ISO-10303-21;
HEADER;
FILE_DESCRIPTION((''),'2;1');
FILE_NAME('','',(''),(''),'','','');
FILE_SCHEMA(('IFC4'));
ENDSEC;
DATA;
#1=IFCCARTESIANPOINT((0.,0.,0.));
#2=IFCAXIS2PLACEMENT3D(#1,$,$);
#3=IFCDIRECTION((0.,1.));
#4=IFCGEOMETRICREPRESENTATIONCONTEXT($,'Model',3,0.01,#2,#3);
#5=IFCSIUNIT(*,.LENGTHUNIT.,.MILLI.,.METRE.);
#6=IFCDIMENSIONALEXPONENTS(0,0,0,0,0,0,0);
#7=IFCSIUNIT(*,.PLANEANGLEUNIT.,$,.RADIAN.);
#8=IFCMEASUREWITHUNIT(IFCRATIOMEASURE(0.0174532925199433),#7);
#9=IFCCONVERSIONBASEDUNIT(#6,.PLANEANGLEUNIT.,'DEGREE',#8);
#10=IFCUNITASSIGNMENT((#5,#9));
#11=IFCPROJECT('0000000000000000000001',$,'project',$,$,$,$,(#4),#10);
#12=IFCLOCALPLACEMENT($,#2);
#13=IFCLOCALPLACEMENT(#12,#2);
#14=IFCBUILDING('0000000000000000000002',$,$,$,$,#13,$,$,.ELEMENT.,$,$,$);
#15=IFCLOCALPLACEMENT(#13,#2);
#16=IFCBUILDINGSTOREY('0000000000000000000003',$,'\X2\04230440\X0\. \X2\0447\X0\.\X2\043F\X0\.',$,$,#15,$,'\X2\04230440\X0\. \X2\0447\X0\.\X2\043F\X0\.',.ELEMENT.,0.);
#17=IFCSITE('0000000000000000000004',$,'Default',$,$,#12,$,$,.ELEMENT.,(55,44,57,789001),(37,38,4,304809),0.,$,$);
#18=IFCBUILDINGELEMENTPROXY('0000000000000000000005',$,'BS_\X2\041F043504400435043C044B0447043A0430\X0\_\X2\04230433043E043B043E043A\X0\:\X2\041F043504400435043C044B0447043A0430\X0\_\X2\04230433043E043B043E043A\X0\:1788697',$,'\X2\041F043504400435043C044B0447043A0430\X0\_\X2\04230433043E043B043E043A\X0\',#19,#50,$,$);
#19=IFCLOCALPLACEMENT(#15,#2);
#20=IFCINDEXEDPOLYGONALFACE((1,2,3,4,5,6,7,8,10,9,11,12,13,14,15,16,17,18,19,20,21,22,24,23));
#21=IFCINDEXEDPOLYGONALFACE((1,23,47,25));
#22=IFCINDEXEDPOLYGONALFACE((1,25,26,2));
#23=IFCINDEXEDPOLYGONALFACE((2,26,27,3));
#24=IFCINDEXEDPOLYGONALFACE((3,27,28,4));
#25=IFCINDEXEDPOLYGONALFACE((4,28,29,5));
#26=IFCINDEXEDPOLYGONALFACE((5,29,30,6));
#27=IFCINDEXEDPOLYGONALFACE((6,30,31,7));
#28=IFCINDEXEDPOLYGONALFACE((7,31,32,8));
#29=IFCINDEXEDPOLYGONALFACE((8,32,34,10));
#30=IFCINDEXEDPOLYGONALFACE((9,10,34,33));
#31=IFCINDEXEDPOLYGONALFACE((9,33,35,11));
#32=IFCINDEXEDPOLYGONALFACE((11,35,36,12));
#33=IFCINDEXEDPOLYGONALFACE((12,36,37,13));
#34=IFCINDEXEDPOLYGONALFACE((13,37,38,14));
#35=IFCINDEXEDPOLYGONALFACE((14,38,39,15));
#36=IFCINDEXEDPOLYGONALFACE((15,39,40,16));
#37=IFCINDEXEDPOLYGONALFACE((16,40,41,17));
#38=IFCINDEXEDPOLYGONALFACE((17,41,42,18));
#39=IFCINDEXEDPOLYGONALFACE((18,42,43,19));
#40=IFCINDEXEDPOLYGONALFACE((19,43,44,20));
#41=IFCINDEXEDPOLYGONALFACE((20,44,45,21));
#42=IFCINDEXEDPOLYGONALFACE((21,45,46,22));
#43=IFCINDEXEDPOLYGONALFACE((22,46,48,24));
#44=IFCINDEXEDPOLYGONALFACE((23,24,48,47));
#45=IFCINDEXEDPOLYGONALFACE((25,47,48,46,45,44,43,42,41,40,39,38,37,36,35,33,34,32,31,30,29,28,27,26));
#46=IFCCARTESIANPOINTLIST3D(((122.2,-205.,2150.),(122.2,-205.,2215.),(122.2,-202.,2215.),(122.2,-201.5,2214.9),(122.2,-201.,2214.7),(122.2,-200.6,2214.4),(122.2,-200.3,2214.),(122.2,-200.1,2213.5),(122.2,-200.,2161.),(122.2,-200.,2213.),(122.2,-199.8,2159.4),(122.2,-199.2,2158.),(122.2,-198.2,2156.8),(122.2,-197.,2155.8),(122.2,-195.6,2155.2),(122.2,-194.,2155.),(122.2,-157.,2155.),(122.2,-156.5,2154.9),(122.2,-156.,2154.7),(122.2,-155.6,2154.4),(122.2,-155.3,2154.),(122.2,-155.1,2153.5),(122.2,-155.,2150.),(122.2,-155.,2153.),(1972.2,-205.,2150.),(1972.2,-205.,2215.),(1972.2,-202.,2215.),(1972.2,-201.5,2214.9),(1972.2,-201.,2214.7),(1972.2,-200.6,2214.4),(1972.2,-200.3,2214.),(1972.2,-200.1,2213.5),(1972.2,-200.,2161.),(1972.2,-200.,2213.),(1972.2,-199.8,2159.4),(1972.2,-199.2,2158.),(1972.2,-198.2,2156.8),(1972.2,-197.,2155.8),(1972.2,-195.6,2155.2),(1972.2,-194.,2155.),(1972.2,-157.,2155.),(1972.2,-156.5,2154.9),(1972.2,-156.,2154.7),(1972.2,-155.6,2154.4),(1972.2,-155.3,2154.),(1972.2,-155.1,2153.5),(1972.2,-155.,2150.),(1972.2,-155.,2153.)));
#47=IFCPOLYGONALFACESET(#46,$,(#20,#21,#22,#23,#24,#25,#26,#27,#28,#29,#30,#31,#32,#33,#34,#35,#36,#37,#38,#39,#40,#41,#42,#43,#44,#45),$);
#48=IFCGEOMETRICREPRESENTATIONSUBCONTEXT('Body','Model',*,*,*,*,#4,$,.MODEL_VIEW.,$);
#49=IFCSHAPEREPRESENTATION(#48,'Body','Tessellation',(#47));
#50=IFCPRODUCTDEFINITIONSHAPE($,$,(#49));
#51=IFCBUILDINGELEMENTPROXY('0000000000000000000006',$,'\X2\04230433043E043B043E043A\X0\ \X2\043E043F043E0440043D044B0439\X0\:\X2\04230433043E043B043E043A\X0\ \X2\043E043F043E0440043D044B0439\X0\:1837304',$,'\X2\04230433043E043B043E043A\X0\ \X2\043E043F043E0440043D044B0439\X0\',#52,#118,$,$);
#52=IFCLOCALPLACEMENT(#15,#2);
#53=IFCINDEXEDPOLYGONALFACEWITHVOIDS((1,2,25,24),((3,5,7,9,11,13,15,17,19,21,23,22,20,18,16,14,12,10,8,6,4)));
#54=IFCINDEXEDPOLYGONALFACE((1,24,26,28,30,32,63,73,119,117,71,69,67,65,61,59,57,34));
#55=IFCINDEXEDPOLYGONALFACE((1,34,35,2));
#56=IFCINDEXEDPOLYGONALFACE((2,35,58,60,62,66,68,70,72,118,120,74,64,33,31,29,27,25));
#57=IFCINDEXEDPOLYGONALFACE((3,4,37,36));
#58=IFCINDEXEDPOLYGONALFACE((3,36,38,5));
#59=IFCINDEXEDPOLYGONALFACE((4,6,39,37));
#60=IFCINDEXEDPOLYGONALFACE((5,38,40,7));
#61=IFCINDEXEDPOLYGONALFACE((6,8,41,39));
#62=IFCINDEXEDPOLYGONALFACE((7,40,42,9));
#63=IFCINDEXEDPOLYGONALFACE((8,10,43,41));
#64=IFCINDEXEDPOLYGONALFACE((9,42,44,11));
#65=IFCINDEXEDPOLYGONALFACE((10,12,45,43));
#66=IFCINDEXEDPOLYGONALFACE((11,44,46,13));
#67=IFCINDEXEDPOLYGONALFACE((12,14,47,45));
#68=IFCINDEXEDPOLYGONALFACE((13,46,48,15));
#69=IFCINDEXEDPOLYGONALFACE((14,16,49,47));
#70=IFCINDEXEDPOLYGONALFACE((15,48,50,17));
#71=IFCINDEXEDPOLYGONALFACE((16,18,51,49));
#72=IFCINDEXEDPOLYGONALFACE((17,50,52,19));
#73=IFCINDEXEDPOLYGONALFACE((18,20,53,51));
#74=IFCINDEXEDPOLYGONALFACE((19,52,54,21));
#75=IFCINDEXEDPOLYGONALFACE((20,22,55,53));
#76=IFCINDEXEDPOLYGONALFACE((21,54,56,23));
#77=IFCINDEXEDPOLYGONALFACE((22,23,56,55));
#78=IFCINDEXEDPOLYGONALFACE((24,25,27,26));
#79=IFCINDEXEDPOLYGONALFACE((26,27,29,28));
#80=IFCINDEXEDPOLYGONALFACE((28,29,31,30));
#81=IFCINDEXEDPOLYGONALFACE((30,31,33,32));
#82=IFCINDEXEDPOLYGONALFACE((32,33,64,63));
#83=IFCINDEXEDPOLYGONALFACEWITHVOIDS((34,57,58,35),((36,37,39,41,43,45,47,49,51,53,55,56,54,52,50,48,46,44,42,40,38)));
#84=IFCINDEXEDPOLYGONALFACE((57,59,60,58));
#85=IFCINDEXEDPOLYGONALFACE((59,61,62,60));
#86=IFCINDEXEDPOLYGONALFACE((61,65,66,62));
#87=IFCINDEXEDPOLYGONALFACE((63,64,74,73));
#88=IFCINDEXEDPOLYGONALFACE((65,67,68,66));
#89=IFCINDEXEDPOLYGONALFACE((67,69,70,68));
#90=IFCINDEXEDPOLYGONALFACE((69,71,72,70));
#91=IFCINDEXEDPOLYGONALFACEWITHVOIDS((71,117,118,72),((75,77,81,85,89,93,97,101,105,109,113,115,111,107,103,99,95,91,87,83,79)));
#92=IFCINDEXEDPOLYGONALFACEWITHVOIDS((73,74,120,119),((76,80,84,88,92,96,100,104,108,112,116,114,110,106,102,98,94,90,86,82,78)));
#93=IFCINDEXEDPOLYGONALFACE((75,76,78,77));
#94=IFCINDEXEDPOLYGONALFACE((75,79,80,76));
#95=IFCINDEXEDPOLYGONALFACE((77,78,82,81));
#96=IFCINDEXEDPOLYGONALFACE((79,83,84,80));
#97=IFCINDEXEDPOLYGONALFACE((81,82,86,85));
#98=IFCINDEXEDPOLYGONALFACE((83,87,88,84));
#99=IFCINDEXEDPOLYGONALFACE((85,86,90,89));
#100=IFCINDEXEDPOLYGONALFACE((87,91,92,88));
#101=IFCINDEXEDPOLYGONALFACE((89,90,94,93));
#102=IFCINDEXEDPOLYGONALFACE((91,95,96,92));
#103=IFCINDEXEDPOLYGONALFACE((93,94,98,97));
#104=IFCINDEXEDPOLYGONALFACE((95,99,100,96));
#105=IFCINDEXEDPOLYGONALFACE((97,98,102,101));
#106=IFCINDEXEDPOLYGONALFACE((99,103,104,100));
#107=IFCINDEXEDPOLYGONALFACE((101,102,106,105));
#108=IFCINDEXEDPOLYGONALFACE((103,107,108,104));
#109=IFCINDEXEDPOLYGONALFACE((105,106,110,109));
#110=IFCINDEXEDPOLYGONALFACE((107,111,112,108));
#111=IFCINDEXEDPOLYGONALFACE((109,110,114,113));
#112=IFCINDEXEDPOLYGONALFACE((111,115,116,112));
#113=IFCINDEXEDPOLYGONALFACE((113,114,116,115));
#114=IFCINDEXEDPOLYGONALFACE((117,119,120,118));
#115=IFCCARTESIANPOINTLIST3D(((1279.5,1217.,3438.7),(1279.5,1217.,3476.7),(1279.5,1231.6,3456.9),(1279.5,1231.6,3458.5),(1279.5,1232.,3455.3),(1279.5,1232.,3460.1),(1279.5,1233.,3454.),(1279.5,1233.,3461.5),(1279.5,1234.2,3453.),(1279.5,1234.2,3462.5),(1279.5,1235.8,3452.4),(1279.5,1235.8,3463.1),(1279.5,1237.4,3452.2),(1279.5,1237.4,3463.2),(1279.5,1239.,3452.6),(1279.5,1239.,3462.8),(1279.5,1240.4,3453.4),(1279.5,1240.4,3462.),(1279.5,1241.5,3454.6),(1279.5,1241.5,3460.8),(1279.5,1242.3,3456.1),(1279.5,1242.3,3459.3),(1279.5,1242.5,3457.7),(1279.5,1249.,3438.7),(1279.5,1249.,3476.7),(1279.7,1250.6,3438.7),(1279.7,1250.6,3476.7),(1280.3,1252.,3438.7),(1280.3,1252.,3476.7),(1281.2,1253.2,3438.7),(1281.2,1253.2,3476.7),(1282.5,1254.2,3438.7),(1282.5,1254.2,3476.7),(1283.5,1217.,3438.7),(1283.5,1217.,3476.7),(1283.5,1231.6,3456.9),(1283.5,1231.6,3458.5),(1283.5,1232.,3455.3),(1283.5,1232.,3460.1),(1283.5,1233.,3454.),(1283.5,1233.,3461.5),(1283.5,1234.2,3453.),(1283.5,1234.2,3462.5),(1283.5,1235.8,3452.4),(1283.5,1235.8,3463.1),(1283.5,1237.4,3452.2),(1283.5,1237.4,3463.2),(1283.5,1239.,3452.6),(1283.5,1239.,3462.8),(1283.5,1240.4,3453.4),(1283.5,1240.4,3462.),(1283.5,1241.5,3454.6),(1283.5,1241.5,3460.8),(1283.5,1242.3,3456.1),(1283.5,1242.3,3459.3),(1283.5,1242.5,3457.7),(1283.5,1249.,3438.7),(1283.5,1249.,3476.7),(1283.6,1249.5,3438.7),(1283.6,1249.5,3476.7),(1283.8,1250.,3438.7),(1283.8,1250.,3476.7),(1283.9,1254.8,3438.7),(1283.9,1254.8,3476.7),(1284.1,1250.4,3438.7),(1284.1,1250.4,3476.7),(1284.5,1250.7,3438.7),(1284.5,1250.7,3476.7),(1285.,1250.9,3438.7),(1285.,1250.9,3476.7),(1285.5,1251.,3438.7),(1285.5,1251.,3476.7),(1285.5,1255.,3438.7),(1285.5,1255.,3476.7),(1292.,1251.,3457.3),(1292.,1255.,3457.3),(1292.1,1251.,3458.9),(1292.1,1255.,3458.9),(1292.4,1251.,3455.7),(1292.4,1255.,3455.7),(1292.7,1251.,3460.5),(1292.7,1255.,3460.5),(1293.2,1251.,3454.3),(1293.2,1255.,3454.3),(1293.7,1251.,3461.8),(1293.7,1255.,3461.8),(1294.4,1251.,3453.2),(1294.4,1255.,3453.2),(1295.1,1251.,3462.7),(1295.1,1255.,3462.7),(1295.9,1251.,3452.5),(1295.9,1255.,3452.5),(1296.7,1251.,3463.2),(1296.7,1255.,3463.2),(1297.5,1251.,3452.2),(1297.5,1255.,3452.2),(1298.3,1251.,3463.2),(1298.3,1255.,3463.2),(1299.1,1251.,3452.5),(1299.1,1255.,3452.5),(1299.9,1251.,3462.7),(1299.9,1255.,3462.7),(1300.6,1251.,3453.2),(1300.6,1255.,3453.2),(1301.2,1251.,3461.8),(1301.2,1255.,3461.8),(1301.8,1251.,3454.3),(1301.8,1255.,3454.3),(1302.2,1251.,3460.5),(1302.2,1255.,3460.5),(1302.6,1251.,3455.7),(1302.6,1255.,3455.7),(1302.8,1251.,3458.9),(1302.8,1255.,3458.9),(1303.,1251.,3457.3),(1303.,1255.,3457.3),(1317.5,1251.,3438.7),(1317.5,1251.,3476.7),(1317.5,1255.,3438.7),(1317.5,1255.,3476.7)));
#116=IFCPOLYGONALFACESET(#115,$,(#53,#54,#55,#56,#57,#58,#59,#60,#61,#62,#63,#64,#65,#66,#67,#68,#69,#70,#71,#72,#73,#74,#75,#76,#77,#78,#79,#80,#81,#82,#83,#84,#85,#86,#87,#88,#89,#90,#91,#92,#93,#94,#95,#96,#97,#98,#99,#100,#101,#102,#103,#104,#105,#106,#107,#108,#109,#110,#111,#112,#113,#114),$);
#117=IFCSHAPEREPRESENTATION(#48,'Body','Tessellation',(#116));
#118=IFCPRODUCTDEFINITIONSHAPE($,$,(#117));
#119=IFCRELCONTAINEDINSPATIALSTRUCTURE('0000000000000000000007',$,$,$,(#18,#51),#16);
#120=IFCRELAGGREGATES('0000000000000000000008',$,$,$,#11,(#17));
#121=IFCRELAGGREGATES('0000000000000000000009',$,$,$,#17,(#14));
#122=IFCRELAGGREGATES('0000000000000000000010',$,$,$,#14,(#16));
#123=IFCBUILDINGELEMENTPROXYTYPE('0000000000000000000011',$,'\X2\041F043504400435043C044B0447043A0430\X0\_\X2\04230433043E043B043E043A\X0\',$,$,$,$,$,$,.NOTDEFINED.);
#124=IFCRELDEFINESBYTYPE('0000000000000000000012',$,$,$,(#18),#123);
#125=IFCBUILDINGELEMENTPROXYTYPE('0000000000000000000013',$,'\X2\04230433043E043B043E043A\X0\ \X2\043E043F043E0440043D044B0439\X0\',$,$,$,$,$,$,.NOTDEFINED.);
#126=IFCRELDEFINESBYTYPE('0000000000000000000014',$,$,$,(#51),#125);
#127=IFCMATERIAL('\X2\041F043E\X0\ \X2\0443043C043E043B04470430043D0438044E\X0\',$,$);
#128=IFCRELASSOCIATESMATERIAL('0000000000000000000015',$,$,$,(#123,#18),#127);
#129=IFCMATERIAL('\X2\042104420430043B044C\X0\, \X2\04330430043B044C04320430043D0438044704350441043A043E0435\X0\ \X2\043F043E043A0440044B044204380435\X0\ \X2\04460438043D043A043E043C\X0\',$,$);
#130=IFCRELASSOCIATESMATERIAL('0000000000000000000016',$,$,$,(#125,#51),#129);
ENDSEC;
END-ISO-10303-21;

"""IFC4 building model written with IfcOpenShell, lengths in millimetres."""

from ifc_helpers import new_model, entity, si_unit, converted_unit, direction, frame, frame_2d, origin, place, context, subcontext, project, spatial, polyline, circle_curve, parameter, trimmed, segment, composite_curve, circle, outline, extrude, source, transform, mapped, material, type_object, type_shapes, element, save


model = new_model("IFC4")

# Units and contexts
model_context = context("Model", 3, precision=0.01, world=origin(), true_north=direction((0.0, 1.0)))
body_context = subcontext(model_context, "Body", "Model", "MODEL_VIEW")
ifc_project = project(units=[si_unit("LENGTHUNIT", "METRE", prefix="MILLI"), converted_unit("PLANEANGLEUNIT", "DEGREE", entity("IfcRatioMeasure", 0.0174532925199433), si_unit("PLANEANGLEUNIT", "RADIAN"), dimensions=[0, 0, 0, 0, 0, 0, 0])], contexts=[model_context])

# Site, building, storey
site_placement = place(None, origin())
site = spatial("IfcSite", under=ifc_project, at=site_placement, Name="Default", CompositionType="ELEMENT", RefLatitude=(55, 44, 57, 789001), RefLongitude=(37, 38, 4, 304809), RefElevation=0.0)
building_placement = place(site_placement, origin())
building = spatial("IfcBuilding", under=site, at=building_placement, CompositionType="ELEMENT")
storey_placement = place(building_placement, origin())
storey = spatial("IfcBuildingStorey", under=building, at=storey_placement, Name="Ур. ч.п.", LongName="Ур. ч.п.", CompositionType="ELEMENT", Elevation=0.0)

# Building element proxy
ifc_material_1 = material(Name="По умолчанию")
building_element_proxy_type_1 = type_object("IfcBuildingElementProxyType", Name="Перемычка_Уголок", material=ifc_material_1)
shared_shape_1 = source(origin(), body_context, "Body", "SweptSolid", [
    extrude(outline(composite_curve([segment(polyline([(-24.1, -19.1), (40.9, -19.1)]), True, "CONTINUOUS"), segment(polyline([(40.9, -19.1), (40.9, -16.1)]), True, "CONTINUOUS"), segment(trimmed(circle_curve(frame_2d((38.9, -16.1), x_axis=(0.0, 1.0)), 2.0), [parameter(270.0)], [parameter(0.0)], True, "PARAMETER"), True, "CONTINUOUS"), segment(polyline([(38.9, -14.1), (-13.1, -14.1)]), True, "CONTINUOUS"), segment(trimmed(circle_curve(frame_2d((-13.1, -8.1), x_axis=(0.0, 1.0)), 6.0), [parameter(90.0)], [parameter(180.0)], True, "PARAMETER"), False, "CONTINUOUS"), segment(polyline([(-19.1, -8.1), (-19.1, 28.9)]), True, "CONTINUOUS"), segment(trimmed(circle_curve(frame_2d((-21.1, 28.9), x_axis=(0.0, 1.0)), 2.0), [parameter(270.0)], [parameter(0.0)], True, "PARAMETER"), True, "CONTINUOUS"), segment(polyline([(-21.1, 30.9), (-24.1, 30.9)]), True, "CONTINUOUS"), segment(polyline([(-24.1, 30.9), (-24.1, -19.1)]), True, "CONTINUOUS")], self_intersect=False)), frame((0.0, 32.5, 24.1), z_axis=(1.0, 0.0, 0.0), x_axis=(0.0, 0.0, 1.0)), (0.0, 0.0, 1.0), 1850.0),
])
type_shapes(building_element_proxy_type_1, [shared_shape_1])
proxy_1_placement = place(storey_placement, frame((1972.2, -153.4, 2150.0), z_axis=(0.0, 0.0, 1.0), x_axis=(-1.0, 0.0, 0.0)))
element("IfcBuildingElementProxy", 1, at=proxy_1_placement, inside=storey, type_object=building_element_proxy_type_1, material=ifc_material_1, Name="BS_Перемычка_Уголок:Перемычка_Уголок:1788697", ObjectType="Перемычка_Уголок", context=body_context, shape_type="MappedRepresentation", body=[
    mapped(shared_shape_1, transform((0.0, 0.0, 0.0), scale=1.0)),
])

# Building element proxy, openings
ifc_material_2 = material(Name="Сталь, гальваническое покрытие цинком")
building_element_proxy_type_2 = type_object("IfcBuildingElementProxyType", Name="Уголок опорный", material=ifc_material_2)
shared_shape_2 = source(origin(), body_context, "Body", "SweptSolid", [
    extrude(outline(composite_curve([segment(polyline([(-6.0, -12.0), (26.0, -12.0)]), True, "CONTINUOUS"), segment(polyline([(26.0, -12.0), (26.0, -8.0)]), True, "CONTINUOUS"), segment(polyline([(26.0, -8.0), (-6.0, -8.0)]), True, "CONTINUOUS"), segment(trimmed(circle_curve(frame_2d((-6.0, -6.0), x_axis=(0.0, -1.0)), 2.0), [parameter(270.0)], [parameter(0.0)], True, "PARAMETER"), False, "CONTINUOUS"), segment(polyline([(-8.0, -6.0), (-8.0, 26.0)]), True, "CONTINUOUS"), segment(polyline([(-8.0, 26.0), (-12.0, 26.0)]), True, "CONTINUOUS"), segment(polyline([(-12.0, 26.0), (-12.0, -6.0)]), True, "CONTINUOUS"), segment(trimmed(circle_curve(frame_2d((-6.0, -6.0), x_axis=(0.0, -1.0)), 6.0), [parameter(270.0)], [parameter(360.0)], True, "PARAMETER"), True, "CONTINUOUS")], self_intersect=False)), frame((12.0, -19.0, 12.0), z_axis=(0.0, 1.0, 0.0), x_axis=(0.0, 0.0, 1.0)), (0.0, 0.0, 1.0), 38.0),
])
type_shapes(building_element_proxy_type_2, [shared_shape_2])
proxy_2_placement = place(storey_placement, frame((1279.5, 1255.0, 3457.7), z_axis=(0.0, -1.0, 0.0), x_axis=(1.0, 0.0, 0.0)))
proxy_2 = element("IfcBuildingElementProxy", 2, at=proxy_2_placement, inside=storey, type_object=building_element_proxy_type_2, material=ifc_material_2, Name="Уголок опорный:Уголок опорный:1837304", ObjectType="Уголок опорный", context=body_context, shape_type="MappedRepresentation", body=[
    mapped(shared_shape_2, transform((0.0, 0.0, 0.0), scale=1.0)),
])
opening_1_placement = place(storey_placement, frame((1279.5, 1255.0, 3457.7), z_axis=(0.0, 0.0, -1.0), x_axis=(1.0, 0.0, 0.0)))
element("IfcOpeningElement", 3, at=opening_1_placement, cuts=proxy_2, ObjectType="Opening", PredefinedType="OPENING", context=body_context, shape_type="SweptSolid", body=[
    extrude(circle(Radius=5.5, at=frame_2d((0.0, 0.0), x_axis=(1.0, 0.0))), frame((4.0, 18.0, 0.0), z_axis=(-1.0, 0.0, 0.0), x_axis=(0.0, -1.0, 0.0)), (0.0, 0.0, 1.0), 4.0),
])
opening_2_placement = place(storey_placement, frame((1279.5, 1255.0, 3457.7), z_axis=(0.0, 0.0, -1.0), x_axis=(1.0, 0.0, 0.0)))
element("IfcOpeningElement", 4, at=opening_2_placement, cuts=proxy_2, ObjectType="Opening", PredefinedType="OPENING", context=body_context, shape_type="SweptSolid", body=[
    extrude(circle(Radius=5.5, at=frame_2d((0.0, 0.0), x_axis=(1.0, 0.0))), frame((18.0, 0.0, 0.0), z_axis=(0.0, 1.0, 0.0), x_axis=(0.0, 0.0, 1.0)), (0.0, 0.0, 1.0), 4.0),
])

save(model, "model.ifc")
